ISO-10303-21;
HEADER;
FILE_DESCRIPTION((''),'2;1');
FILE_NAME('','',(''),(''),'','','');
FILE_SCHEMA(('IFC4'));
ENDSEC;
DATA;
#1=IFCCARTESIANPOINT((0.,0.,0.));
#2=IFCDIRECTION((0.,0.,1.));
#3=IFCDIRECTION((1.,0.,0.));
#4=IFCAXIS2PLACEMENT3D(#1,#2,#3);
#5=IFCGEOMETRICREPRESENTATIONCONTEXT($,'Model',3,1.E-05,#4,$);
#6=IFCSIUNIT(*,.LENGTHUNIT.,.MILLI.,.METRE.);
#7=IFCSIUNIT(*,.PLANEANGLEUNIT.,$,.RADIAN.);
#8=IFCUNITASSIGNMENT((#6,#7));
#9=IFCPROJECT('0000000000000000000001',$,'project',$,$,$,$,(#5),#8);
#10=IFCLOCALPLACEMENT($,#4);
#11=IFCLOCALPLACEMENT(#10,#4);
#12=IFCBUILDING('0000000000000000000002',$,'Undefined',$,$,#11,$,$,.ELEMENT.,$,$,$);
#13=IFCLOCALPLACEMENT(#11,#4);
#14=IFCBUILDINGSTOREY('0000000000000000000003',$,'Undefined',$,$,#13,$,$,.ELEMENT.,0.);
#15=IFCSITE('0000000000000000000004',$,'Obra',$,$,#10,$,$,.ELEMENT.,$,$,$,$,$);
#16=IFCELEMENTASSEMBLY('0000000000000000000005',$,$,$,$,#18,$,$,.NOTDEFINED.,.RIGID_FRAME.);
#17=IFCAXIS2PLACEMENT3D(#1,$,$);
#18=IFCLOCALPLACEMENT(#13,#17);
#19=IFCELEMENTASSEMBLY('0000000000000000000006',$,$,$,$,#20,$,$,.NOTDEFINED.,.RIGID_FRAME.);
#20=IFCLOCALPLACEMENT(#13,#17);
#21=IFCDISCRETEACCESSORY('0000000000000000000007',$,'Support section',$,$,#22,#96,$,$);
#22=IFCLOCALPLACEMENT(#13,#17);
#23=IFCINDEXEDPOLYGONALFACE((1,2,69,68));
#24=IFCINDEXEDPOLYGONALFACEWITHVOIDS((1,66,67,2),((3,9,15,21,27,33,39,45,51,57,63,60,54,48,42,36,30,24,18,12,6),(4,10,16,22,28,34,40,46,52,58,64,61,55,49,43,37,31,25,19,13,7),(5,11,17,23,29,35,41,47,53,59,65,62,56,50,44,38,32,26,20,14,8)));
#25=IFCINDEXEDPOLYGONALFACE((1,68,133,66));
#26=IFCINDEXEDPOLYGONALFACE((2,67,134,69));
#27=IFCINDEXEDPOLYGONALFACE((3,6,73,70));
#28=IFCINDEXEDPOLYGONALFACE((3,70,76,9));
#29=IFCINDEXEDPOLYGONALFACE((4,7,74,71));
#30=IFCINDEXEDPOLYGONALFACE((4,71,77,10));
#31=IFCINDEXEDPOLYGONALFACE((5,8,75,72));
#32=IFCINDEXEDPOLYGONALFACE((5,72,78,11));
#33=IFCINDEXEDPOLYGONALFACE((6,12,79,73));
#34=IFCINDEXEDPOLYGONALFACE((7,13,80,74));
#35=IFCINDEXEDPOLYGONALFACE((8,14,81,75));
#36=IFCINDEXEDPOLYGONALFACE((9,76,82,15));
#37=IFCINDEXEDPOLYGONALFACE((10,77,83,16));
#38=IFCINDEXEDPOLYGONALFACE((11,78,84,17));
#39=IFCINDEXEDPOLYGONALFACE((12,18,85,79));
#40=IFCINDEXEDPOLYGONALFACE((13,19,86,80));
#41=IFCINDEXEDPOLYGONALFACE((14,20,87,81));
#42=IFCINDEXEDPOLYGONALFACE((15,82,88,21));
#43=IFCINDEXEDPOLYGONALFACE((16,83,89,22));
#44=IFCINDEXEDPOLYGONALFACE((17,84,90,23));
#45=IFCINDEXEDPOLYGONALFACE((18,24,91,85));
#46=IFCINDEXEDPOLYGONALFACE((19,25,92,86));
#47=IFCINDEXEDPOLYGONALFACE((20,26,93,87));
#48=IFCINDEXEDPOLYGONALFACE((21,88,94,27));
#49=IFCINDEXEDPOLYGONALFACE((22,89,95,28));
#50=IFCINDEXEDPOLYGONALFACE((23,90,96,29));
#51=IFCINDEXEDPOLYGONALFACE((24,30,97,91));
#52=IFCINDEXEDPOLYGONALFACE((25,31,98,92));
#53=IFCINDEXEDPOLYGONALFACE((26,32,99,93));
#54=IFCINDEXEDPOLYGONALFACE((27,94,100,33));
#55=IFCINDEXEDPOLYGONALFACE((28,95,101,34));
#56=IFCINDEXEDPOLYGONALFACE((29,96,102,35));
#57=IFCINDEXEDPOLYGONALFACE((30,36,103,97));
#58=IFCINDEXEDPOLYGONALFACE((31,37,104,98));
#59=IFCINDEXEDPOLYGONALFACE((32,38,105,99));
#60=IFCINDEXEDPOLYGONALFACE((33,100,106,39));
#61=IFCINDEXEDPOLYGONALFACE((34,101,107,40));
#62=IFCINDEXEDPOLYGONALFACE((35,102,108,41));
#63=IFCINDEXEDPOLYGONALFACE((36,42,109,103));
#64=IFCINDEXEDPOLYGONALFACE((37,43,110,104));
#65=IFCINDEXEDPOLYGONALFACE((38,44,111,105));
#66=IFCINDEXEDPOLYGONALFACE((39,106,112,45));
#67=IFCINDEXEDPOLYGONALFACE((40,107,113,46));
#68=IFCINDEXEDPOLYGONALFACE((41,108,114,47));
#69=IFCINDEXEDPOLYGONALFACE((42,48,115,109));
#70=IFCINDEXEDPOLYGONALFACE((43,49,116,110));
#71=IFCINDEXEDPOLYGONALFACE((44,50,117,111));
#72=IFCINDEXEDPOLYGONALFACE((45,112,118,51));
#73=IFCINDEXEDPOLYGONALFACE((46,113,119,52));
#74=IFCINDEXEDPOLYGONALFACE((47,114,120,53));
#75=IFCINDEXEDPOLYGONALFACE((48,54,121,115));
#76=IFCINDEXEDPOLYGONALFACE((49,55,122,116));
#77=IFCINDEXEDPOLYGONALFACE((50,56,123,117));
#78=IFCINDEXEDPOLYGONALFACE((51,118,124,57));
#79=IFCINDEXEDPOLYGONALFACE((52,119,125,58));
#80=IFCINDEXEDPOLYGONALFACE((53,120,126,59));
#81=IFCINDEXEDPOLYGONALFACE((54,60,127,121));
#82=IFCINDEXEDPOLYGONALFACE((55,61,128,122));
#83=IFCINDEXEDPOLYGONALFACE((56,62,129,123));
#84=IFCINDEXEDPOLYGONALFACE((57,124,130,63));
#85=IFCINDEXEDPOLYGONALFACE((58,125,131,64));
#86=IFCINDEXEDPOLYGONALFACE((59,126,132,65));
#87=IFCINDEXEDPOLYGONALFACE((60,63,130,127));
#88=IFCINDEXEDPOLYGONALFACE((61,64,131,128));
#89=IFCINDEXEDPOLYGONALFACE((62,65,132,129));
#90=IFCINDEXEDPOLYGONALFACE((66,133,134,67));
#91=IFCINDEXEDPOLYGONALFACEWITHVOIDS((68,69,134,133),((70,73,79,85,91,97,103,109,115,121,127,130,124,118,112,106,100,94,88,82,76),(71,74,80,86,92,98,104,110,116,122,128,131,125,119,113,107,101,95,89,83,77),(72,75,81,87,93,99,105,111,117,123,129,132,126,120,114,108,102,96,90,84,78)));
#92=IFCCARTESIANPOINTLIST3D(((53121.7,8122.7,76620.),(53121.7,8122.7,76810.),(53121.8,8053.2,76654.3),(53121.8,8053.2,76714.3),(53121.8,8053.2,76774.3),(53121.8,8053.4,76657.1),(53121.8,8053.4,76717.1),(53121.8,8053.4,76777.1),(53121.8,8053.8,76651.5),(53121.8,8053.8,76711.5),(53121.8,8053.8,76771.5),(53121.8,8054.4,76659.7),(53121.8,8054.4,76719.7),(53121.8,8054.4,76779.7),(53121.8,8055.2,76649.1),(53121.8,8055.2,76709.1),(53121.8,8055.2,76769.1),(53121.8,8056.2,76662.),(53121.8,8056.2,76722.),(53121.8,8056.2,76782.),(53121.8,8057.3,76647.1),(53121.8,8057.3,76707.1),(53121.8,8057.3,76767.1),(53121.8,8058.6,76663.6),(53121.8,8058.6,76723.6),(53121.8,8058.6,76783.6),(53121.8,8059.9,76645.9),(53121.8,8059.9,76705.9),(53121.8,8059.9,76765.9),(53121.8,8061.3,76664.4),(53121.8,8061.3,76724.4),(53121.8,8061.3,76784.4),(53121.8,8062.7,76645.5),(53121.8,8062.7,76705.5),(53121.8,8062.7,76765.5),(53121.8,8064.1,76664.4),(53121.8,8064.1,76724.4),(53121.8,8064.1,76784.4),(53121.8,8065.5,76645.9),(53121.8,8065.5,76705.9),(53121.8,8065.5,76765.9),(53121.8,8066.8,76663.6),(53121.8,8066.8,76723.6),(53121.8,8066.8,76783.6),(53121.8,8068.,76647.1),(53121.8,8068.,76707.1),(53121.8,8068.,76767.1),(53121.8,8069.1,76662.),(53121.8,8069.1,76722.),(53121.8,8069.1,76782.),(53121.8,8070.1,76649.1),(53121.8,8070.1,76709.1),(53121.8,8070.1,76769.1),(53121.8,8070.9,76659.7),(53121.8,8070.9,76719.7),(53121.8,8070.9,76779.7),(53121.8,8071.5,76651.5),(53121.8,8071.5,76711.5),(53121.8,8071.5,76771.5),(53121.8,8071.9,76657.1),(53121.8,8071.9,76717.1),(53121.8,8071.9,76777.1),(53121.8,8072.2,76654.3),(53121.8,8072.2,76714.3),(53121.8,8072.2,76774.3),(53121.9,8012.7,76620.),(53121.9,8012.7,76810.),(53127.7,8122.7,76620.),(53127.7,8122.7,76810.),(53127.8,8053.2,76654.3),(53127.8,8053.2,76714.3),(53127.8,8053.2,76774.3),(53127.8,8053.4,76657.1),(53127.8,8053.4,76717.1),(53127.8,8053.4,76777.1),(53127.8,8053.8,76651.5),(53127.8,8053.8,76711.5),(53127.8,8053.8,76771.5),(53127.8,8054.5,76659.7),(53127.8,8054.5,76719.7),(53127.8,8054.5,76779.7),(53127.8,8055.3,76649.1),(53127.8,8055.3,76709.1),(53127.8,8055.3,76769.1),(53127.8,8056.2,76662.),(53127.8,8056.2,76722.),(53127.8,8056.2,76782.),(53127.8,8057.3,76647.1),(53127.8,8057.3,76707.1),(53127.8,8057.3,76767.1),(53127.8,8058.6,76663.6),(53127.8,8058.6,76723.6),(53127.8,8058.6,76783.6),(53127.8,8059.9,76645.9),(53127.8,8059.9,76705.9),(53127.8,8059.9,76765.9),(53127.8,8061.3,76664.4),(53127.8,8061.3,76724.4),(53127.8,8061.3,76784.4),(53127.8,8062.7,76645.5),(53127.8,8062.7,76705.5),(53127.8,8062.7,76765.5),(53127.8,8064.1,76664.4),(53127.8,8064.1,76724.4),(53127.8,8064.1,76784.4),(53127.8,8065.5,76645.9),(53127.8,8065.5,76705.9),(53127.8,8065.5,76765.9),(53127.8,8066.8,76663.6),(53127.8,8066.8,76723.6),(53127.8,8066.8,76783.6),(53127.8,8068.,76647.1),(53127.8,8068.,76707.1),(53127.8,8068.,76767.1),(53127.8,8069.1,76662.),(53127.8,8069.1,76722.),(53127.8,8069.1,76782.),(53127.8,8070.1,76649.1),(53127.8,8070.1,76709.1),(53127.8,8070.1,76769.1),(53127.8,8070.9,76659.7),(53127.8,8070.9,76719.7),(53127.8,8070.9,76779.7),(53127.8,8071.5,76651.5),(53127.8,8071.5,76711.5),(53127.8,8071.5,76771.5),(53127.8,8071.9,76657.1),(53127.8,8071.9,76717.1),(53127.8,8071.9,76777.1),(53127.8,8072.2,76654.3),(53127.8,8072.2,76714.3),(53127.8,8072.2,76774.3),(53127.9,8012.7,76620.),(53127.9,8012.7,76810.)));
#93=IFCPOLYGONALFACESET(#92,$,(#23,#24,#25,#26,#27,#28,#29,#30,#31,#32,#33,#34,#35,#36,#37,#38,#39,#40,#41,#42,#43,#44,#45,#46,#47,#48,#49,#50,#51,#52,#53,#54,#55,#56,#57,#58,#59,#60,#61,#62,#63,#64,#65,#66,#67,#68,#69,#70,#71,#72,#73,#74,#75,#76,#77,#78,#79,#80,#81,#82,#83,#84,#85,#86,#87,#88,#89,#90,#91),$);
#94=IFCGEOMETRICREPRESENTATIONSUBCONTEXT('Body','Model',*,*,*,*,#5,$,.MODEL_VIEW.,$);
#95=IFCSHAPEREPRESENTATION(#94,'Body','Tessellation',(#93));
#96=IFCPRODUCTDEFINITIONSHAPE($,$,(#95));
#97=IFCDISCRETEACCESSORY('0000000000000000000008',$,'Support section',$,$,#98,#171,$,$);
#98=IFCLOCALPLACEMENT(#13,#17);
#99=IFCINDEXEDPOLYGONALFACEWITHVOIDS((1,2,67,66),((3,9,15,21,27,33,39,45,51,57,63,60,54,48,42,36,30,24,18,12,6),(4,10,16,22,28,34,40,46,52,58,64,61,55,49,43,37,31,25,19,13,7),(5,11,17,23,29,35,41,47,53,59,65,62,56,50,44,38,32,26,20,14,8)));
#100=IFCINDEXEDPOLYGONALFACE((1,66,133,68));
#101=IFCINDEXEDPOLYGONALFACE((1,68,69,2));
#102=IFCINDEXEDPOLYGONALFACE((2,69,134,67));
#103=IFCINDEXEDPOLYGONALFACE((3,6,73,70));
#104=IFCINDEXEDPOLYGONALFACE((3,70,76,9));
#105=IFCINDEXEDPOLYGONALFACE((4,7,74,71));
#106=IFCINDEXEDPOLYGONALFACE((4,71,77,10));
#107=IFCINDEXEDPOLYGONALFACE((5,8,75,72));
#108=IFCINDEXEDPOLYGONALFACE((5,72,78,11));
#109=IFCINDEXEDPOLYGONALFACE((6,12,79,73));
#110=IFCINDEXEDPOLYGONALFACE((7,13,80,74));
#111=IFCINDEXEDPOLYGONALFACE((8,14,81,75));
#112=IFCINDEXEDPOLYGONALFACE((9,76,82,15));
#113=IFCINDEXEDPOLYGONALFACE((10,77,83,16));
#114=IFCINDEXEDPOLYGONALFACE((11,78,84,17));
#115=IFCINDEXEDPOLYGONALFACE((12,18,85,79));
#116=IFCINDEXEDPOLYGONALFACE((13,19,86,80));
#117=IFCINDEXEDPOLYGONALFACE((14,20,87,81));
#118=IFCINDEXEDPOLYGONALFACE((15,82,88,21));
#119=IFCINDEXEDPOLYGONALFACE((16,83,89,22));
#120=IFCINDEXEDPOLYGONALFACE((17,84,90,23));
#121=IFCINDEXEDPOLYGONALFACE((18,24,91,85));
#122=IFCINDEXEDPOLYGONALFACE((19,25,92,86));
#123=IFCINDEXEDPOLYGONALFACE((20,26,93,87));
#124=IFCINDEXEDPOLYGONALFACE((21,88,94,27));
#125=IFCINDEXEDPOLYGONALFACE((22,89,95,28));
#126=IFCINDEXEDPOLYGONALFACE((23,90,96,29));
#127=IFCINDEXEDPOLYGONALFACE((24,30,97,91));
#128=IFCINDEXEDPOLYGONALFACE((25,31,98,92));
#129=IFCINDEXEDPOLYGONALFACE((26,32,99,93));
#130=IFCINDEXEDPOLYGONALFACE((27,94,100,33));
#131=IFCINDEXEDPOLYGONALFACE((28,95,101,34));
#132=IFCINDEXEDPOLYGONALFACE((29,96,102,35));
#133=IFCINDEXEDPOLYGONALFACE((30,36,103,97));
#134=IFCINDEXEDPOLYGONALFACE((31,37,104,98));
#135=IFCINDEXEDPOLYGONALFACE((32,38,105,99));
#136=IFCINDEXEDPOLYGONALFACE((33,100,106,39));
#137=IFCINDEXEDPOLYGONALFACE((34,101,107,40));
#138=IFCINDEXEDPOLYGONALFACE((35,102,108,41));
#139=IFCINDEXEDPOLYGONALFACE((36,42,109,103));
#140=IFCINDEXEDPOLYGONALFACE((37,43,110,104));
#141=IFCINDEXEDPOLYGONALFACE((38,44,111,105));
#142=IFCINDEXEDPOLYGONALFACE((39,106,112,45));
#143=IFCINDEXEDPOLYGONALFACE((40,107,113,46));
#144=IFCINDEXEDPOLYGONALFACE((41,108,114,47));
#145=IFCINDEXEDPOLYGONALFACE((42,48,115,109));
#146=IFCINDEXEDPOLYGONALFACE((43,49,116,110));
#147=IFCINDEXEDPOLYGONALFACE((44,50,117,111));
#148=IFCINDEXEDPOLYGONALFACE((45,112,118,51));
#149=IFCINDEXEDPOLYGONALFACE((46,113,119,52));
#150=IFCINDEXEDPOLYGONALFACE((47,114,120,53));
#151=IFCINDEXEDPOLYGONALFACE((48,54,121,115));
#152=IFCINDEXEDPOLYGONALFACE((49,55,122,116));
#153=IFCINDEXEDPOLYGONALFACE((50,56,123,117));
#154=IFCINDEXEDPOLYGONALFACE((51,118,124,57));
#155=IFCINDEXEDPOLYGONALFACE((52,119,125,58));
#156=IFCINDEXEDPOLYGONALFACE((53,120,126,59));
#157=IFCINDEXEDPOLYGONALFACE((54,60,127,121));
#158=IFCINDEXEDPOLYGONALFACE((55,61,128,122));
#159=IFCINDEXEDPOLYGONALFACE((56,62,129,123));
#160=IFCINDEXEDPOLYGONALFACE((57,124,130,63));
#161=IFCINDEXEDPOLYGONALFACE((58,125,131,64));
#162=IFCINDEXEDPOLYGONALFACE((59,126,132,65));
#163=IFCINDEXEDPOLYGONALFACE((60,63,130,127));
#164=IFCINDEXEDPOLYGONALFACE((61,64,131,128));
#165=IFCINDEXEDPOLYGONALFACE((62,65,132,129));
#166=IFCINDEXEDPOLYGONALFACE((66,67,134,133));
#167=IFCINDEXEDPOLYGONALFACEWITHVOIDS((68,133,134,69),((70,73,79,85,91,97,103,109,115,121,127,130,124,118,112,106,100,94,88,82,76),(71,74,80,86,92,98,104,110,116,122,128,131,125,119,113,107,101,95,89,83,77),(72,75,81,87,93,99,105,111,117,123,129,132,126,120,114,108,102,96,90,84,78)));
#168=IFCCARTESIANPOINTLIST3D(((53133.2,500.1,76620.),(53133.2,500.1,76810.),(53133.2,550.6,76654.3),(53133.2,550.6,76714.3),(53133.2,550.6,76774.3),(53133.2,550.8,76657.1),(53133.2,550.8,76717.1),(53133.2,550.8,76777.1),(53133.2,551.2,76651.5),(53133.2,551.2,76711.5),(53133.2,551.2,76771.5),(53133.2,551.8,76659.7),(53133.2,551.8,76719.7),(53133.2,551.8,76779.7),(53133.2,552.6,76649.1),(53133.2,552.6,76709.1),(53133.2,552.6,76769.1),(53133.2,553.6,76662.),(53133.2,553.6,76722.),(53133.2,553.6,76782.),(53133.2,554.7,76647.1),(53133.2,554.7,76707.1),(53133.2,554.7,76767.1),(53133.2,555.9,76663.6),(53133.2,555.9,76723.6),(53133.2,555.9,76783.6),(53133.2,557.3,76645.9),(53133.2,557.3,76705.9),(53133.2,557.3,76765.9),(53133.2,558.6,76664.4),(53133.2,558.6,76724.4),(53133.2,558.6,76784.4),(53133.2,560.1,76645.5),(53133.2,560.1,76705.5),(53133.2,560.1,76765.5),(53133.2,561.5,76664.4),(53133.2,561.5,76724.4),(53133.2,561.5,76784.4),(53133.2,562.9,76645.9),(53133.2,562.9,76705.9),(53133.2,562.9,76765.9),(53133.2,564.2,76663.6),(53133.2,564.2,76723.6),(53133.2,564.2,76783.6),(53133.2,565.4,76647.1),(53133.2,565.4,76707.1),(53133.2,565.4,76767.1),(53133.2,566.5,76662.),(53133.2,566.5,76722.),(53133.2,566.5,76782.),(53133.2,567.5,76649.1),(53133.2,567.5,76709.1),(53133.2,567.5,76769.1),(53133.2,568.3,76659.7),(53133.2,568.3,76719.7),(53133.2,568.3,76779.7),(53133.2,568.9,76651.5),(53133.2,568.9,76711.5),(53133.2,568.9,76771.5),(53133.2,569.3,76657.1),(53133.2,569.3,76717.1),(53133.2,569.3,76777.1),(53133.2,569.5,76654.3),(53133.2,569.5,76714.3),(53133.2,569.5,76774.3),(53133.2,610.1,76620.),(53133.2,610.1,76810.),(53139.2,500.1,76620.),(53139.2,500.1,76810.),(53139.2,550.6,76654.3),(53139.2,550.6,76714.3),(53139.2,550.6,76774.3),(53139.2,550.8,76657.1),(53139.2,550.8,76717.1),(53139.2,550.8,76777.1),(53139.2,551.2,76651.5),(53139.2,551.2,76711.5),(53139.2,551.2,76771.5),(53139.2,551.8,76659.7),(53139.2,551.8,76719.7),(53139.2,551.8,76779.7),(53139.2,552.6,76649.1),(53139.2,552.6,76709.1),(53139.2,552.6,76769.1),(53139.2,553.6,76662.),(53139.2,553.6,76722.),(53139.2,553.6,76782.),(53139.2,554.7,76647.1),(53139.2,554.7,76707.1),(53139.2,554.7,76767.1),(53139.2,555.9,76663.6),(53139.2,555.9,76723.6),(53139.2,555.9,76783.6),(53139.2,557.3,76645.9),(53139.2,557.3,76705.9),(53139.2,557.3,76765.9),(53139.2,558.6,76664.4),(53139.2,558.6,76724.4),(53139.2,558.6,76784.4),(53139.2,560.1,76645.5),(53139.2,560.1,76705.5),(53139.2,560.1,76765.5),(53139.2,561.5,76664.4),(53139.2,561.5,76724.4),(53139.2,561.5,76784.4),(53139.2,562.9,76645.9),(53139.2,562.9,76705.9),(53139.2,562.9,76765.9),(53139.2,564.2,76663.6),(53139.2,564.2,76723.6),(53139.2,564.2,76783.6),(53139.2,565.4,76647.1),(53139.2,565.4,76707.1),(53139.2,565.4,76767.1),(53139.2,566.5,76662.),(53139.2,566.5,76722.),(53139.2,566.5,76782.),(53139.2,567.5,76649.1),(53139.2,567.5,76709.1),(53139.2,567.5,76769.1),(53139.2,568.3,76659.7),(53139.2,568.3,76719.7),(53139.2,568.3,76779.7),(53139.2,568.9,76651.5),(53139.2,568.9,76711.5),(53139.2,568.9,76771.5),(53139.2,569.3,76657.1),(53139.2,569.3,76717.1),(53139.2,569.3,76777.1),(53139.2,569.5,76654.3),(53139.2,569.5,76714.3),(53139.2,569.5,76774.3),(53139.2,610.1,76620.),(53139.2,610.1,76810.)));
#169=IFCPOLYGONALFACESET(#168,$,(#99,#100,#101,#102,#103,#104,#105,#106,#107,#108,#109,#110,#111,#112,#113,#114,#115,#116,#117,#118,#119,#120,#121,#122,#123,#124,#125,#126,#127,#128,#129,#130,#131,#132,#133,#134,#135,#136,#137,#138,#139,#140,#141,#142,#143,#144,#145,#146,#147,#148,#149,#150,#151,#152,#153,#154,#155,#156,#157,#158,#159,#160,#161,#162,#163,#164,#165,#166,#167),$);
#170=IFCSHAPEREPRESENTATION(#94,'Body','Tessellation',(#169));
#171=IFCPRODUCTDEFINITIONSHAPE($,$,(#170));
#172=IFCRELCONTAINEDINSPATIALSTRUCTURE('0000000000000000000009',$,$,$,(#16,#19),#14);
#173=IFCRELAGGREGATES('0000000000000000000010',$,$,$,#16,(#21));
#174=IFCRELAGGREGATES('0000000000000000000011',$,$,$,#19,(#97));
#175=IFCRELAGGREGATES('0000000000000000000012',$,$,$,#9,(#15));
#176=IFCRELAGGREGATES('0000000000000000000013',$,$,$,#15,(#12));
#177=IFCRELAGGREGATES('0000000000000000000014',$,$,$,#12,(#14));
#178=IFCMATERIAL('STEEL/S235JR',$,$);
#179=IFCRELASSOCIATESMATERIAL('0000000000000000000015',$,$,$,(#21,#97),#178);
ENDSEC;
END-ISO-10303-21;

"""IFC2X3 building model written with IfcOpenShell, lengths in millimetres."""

from ifc_helpers import new_model, si_unit, frame, origin_with_axes, origin_2d_with_axis, place, context, subcontext, project, spatial, rectangle, circle, extrude, source, transform, mapped, material, element, aggregate, save


model = new_model("IFC2X3")

# Units and contexts
model_context = context("Model", 3, precision=1e-05, world=origin_with_axes())
body_context = subcontext(model_context, "Body", "Model", "MODEL_VIEW")
ifc_project = project(units=[si_unit("LENGTHUNIT", "METRE", prefix="MILLI"), si_unit("PLANEANGLEUNIT", "RADIAN")], contexts=[model_context])

# Site, building, storey
site_placement = place(None, origin_with_axes())
site = spatial("IfcSite", under=ifc_project, at=site_placement, Name="Obra", CompositionType="ELEMENT")
building_placement = place(site_placement, origin_with_axes())
building = spatial("IfcBuilding", under=site, at=building_placement, Name="Undefined", CompositionType="ELEMENT")
storey_placement = place(building_placement, origin_with_axes())
storey = spatial("IfcBuildingStorey", under=building, at=storey_placement, Name="Undefined", CompositionType="ELEMENT", Elevation=0.0)

# Element assemblies
ifc_material_1 = material(Name="STEEL/S235JR")
assembly_1_placement = place(storey_placement, origin_with_axes())
assembly_1 = element("IfcElementAssembly", 1, at=assembly_1_placement, inside=storey, AssemblyPlace="NOTDEFINED", PredefinedType="RIGID_FRAME")
assembly_2_placement = place(storey_placement, origin_with_axes())
assembly_2 = element("IfcElementAssembly", 2, at=assembly_2_placement, inside=storey, AssemblyPlace="NOTDEFINED", PredefinedType="RIGID_FRAME")

# Discrete accessories, openings
shared_shape_1 = source(origin_with_axes(), body_context, "Body", "SweptSolid", [
    extrude(circle(Radius=9.5, at=origin_2d_with_axis()), frame((0.0, -9.2, 0.0), z_axis=(0.0, 1.0, 0.0), x_axis=(1.0, 0.0, 0.0)), (0.0, 0.0, 1.0), 6.2),
])
discrete_accessory_1_placement = place(assembly_1_placement, frame((53124.8, 8067.7, 76620.0), z_axis=(0.0, 0.0, 1.0), x_axis=(-0.001508, 0.999999, 0.0)))
discrete_accessory_1 = element("IfcDiscreteAccessory", 3, at=discrete_accessory_1_placement, material=ifc_material_1, Name="Support section", context=body_context, shape_type="SweptSolid", body=[
    extrude(rectangle(XDim=6.0, YDim=110.0, at=origin_2d_with_axis()), frame((0.0, 0.0, 190.0), z_axis=(0.0, 0.0, -1.0), x_axis=(0.0, 1.0, 0.0)), (0.0, 0.0, 1.0), 190.0),
])
opening_1_placement = place(assembly_1_placement, frame((53130.9, 8112.7, 76835.0), z_axis=(0.001508, -0.999999, 0.0), x_axis=(0.0, 0.0, -1.0)))
element("IfcOpeningElement", 4, at=opening_1_placement, cuts=discrete_accessory_1, ObjectType="Opening", context=body_context, shape_type="MappedRepresentation", body=[
    mapped(shared_shape_1, transform((60.0, 0.0, 50.0))),
    mapped(shared_shape_1, transform((120.0, 0.0, 50.0))),
    mapped(shared_shape_1, transform((180.0, 0.0, 50.0))),
])
aggregate(assembly_1, [discrete_accessory_1])
discrete_accessory_2_placement = place(assembly_2_placement, frame((53136.2, 555.1, 76620.0), z_axis=(0.0, 0.0, 1.0), x_axis=(0.000002, -1.0, 0.0)))
discrete_accessory_2 = element("IfcDiscreteAccessory", 5, at=discrete_accessory_2_placement, material=ifc_material_1, Name="Support section", context=body_context, shape_type="SweptSolid", body=[
    extrude(rectangle(XDim=6.0, YDim=110.0, at=origin_2d_with_axis()), frame((0.0, 0.0, 190.0), z_axis=(0.0, 0.0, -1.0), x_axis=(0.0, 1.0, 0.0)), (0.0, 0.0, 1.0), 190.0),
])
opening_2_placement = place(assembly_2_placement, frame((53130.1, 510.1, 76835.0), z_axis=(-0.000002, 1.0, 0.0), x_axis=(0.0, 0.0, -1.0)))
element("IfcOpeningElement", 6, at=opening_2_placement, cuts=discrete_accessory_2, ObjectType="Opening", context=body_context, shape_type="MappedRepresentation", body=[
    mapped(shared_shape_1, transform((60.0, 0.0, 50.0))),
    mapped(shared_shape_1, transform((120.0, 0.0, 50.0))),
    mapped(shared_shape_1, transform((180.0, 0.0, 50.0))),
])
aggregate(assembly_2, [discrete_accessory_2])

save(model, "model.ifc")
